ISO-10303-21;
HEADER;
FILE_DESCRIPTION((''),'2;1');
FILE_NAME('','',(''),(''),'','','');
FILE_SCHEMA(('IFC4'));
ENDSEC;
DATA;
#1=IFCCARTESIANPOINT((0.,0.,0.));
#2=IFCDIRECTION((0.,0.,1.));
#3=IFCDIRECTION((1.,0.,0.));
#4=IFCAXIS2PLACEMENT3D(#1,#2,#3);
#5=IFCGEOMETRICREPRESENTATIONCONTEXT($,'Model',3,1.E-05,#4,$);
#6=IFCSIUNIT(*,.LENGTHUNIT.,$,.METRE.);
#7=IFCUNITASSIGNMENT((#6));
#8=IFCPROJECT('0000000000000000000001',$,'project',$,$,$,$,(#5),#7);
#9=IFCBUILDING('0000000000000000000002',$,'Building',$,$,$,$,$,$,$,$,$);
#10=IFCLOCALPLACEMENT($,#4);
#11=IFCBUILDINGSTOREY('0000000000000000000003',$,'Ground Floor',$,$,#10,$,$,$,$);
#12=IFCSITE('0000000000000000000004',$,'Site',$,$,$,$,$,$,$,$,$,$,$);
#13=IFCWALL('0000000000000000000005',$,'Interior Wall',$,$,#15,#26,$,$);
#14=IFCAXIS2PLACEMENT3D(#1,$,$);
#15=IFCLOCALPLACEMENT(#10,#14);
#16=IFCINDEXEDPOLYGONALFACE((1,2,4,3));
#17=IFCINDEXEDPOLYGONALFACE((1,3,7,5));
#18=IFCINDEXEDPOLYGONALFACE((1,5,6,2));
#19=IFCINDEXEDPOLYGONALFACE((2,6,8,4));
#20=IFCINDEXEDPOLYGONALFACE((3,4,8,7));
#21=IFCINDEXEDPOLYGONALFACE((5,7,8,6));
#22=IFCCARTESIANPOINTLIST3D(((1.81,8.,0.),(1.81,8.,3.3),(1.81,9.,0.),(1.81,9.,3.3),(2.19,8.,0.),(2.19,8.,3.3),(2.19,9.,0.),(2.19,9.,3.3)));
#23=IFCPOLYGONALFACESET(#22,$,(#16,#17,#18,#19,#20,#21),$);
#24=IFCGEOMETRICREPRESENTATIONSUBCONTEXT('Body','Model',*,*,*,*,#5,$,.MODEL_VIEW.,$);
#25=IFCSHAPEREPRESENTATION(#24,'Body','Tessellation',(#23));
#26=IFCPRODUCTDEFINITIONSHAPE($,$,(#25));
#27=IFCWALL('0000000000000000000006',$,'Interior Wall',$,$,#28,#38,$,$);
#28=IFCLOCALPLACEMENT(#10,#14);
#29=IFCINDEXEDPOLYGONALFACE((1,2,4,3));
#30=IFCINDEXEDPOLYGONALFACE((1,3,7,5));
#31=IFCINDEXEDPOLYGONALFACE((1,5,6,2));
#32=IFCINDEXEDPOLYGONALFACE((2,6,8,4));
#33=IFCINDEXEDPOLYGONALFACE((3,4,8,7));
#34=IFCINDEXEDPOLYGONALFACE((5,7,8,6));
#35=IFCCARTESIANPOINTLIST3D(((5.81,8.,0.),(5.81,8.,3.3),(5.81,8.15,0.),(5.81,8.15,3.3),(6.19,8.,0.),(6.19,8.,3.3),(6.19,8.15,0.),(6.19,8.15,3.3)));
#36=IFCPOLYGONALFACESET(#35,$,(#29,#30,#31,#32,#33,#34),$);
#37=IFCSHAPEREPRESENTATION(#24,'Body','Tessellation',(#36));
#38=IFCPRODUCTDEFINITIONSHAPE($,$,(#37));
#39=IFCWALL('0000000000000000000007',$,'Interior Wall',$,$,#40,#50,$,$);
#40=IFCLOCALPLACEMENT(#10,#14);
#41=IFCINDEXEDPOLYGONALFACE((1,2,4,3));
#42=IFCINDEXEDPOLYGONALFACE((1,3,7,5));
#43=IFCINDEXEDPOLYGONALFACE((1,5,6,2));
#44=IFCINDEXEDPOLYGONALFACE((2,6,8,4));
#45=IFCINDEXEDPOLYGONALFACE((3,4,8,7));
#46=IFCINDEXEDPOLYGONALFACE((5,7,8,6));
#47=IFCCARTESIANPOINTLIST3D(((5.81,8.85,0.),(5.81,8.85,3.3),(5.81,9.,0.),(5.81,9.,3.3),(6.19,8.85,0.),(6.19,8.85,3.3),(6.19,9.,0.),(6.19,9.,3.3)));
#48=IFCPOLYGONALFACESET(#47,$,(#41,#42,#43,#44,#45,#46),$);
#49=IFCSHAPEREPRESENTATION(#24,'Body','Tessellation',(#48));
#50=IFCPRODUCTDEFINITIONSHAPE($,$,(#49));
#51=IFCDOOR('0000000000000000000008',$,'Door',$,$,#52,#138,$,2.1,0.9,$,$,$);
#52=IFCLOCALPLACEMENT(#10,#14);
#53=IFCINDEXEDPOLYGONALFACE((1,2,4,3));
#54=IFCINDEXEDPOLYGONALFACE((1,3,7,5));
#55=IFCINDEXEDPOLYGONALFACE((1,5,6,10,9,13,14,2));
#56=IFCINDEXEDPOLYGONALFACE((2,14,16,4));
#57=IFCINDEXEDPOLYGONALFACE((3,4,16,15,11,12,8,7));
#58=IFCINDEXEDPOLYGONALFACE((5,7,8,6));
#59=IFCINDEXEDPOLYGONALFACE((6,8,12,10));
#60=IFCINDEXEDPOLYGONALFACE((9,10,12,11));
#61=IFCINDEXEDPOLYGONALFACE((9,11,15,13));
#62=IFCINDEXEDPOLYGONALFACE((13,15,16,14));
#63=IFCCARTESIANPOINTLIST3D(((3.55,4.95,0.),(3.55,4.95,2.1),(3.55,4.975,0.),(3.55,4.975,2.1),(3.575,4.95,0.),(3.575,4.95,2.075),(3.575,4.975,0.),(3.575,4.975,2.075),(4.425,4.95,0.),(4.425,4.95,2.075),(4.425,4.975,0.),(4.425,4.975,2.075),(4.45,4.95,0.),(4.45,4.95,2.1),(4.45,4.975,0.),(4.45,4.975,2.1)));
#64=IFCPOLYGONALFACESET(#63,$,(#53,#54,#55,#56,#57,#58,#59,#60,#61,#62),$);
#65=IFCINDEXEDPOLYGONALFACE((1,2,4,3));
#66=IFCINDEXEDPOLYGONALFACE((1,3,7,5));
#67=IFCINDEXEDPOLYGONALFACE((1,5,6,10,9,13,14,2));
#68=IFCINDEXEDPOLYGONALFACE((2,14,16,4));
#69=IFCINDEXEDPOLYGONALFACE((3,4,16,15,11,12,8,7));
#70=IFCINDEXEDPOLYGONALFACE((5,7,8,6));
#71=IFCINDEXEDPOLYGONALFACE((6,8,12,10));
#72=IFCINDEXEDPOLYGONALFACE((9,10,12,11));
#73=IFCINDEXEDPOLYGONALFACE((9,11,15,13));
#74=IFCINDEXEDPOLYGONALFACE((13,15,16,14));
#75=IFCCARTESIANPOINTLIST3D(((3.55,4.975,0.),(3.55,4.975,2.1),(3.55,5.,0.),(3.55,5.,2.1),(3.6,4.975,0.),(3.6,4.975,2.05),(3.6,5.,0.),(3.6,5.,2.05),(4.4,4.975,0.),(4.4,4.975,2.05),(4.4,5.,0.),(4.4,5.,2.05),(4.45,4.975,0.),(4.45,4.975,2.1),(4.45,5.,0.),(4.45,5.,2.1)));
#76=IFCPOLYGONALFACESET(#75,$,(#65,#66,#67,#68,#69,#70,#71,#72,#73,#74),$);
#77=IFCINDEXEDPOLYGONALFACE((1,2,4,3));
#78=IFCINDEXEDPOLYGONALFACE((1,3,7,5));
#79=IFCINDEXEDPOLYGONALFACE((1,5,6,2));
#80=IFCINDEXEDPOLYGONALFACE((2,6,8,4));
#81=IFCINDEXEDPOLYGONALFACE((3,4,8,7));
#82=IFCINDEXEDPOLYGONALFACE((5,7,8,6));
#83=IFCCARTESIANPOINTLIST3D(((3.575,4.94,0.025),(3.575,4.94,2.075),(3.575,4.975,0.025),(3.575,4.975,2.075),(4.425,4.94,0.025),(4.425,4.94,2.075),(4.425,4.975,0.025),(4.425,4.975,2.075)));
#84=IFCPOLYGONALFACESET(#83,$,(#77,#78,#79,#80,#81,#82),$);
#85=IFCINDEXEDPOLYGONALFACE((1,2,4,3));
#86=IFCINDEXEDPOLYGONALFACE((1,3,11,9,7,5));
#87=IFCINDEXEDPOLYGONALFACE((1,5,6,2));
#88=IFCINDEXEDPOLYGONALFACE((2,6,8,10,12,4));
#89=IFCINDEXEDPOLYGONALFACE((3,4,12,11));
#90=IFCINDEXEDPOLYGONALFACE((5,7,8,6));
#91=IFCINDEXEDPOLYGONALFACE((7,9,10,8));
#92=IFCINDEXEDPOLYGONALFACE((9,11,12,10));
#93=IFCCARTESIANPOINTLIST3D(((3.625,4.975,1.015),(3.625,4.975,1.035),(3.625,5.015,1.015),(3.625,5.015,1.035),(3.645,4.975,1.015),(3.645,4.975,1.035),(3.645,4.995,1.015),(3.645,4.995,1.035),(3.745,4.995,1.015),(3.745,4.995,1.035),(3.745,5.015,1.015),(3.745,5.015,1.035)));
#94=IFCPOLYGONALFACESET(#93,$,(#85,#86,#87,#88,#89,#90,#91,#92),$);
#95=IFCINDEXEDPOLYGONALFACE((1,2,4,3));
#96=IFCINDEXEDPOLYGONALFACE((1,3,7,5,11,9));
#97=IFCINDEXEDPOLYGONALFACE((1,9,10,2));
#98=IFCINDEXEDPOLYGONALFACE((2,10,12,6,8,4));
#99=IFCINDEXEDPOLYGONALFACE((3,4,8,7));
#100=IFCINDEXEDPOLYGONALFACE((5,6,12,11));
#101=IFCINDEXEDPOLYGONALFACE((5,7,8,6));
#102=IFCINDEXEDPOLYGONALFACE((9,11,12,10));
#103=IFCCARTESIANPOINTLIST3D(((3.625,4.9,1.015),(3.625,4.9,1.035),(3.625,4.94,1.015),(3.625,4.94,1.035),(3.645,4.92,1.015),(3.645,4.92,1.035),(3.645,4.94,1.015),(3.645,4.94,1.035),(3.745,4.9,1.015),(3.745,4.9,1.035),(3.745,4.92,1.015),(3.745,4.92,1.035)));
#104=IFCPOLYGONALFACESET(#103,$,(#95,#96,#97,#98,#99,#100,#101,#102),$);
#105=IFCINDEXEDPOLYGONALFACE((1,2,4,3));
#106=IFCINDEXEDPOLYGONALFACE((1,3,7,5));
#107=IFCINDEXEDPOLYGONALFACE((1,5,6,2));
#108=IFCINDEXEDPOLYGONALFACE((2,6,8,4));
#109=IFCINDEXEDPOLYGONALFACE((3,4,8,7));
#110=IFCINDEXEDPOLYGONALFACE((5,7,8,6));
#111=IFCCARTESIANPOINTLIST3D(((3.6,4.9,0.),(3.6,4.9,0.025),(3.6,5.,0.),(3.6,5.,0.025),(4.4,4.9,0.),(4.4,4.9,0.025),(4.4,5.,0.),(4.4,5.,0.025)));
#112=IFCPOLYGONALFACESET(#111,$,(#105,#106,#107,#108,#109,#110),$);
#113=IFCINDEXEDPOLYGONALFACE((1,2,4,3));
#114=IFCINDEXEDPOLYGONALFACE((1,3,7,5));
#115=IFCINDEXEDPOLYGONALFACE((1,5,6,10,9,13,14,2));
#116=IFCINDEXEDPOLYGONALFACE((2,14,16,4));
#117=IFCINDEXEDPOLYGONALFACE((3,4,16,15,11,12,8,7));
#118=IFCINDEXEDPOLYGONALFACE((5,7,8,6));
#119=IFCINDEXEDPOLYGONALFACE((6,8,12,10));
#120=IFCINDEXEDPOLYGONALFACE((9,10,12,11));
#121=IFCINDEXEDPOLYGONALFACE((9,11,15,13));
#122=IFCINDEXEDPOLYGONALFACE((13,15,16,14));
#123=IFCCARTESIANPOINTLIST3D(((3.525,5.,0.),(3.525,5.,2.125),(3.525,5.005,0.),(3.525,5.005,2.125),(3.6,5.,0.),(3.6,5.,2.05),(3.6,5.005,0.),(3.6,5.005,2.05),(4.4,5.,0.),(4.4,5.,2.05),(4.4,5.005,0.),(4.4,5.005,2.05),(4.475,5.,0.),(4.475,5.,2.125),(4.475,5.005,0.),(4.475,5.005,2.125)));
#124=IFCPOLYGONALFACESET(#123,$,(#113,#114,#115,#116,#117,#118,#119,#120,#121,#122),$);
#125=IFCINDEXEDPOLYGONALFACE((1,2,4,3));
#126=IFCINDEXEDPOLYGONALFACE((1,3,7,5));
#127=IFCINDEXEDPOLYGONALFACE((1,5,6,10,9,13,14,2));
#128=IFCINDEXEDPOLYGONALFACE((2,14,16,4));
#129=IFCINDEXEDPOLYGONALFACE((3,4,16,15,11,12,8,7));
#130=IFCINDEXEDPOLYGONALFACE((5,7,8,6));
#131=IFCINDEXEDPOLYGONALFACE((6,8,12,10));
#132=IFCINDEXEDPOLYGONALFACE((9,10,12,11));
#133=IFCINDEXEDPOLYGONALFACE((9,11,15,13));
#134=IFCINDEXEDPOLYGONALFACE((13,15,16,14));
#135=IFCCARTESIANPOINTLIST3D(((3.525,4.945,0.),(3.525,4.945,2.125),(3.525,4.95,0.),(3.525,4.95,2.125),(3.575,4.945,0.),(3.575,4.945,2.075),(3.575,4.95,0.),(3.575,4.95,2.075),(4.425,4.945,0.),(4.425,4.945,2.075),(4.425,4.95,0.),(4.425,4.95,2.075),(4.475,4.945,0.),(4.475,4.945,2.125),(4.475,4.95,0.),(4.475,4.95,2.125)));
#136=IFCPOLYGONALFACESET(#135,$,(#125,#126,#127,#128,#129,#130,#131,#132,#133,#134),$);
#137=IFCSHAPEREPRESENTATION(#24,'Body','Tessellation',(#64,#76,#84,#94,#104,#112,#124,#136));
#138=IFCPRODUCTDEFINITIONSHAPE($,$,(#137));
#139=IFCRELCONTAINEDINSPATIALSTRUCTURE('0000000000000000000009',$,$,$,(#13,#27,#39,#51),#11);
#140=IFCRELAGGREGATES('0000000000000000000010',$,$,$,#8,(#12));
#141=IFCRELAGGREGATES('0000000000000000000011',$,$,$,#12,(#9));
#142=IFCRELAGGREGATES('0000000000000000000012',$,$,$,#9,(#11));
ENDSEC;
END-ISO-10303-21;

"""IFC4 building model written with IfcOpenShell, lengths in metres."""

from ifc_helpers import new_model, si_unit, frame, origin_with_axes, place, context, subcontext, project, spatial, line, indexed_curve, outline, extrude, element, save


model = new_model("IFC4")

# Units and contexts
model_context = context("Model", 3, precision=1e-05, world=origin_with_axes())
body_context = subcontext(model_context, "Body", "Model", "MODEL_VIEW")
ifc_project = project(units=[si_unit("LENGTHUNIT", "METRE")], contexts=[model_context])

# Site, building, storey
site = spatial("IfcSite", under=ifc_project, Name="Site")
building = spatial("IfcBuilding", under=site, Name="Building")
storey_placement = place(None, origin_with_axes())
storey = spatial("IfcBuildingStorey", under=building, at=storey_placement, Name="Ground Floor")

# Walls
wall_1_placement = place(storey_placement, frame((2.0, 8.0, 0.0), z_axis=(0.0, 0.0, 1.0), x_axis=(0.0, 1.0, 0.0)))
element("IfcWall", 1, at=wall_1_placement, inside=storey, Name="Interior Wall", context=body_context, shape_type="SweptSolid", body=[
    extrude(outline(indexed_curve([(0.0, 0.0), (0.0, 0.38), (1.0, 0.38), (1.0, 0.0), (0.0, 0.0)], self_intersect=False)), frame((0.0, -0.19, 0.0), z_axis=(0.0, 0.0, 1.0), x_axis=(1.0, 0.0, 0.0)), (0.0, 0.0, 1.0), 3.3),
])
for number, where, z_axis, x_axis, name in (
    (2, (6.0, 8.0, 0.0), (0.0, 0.0, 1.0), (0.0, 1.0, 0.0), "Interior Wall"),
    (3, (6.0, 8.85, 0.0), (0.0, 0.0, 1.0), (0.0, 1.0, 0.0), "Interior Wall"),
):
    element("IfcWall", number, at=place(storey_placement, frame(where, z_axis=z_axis, x_axis=x_axis)), inside=storey, Name=name, context=body_context, shape_type="SweptSolid", body=[
        extrude(outline(indexed_curve([(0.0, 0.0), (0.0, 0.38), (0.15, 0.38), (0.15, 0.0), (0.0, 0.0)], self_intersect=False)), frame((0.0, -0.19, 0.0), z_axis=(0.0, 0.0, 1.0), x_axis=(1.0, 0.0, 0.0)), (0.0, 0.0, 1.0), 3.3),
    ])

# Door
door_1_placement = place(storey_placement, frame((4.45, 5.0, 0.0), z_axis=(0.0, 0.0, 1.0), x_axis=(-1.0, 0.0, 0.0)))
element("IfcDoor", 4, at=door_1_placement, inside=storey, Name="Door", OverallHeight=2.1, OverallWidth=0.9, context=body_context, shape_type="SweptSolid", body=[
    extrude(outline(indexed_curve([(0.0, 0.0), (0.0, 2.1), (0.9, 2.1), (0.9, 0.0), (0.875, 0.0), (0.875, 2.075), (0.025, 2.075), (0.025, 0.0)], segments=[line(1, 2, 3, 4, 5, 6, 7, 8, 1)])), frame((0.0, 0.025, 0.0), z_axis=(0.0, -1.0, 0.0), x_axis=(1.0, 0.0, 0.0)), (0.0, 0.0, -1.0), 0.025),
    extrude(outline(indexed_curve([(0.0, 0.0), (0.0, 2.1), (0.9, 2.1), (0.9, 0.0), (0.85, 0.0), (0.85, 2.05), (0.05, 2.05), (0.05, 0.0)], segments=[line(1, 2, 3, 4, 5, 6, 7, 8, 1)])), frame((0.0, 0.0, 0.0), z_axis=(0.0, -1.0, 0.0), x_axis=(1.0, 0.0, 0.0)), (0.0, 0.0, -1.0), 0.025),
    extrude(outline(indexed_curve([(0.0, 0.0), (0.85, 0.0), (0.85, 0.035), (0.0, 0.035)], segments=[line(1, 2, 3, 4, 1)])), frame((0.025, 0.025, 0.025), z_axis=(0.0, 0.0, 1.0), x_axis=(1.0, 0.0, 0.0)), (0.0, 0.0, 1.0), 2.05),
    extrude(outline(indexed_curve([(0.0, 0.0), (0.0, -0.04), (-0.12, -0.04), (-0.12, -0.02), (-0.02, -0.02), (-0.02, 0.0)], segments=[line(1, 2, 3, 4, 5, 6, 1)])), frame((0.825, 0.025, 1.015), z_axis=(0.0, 0.0, 1.0), x_axis=(1.0, 0.0, 0.0)), (0.0, 0.0, 1.0), 0.02),
    extrude(outline(indexed_curve([(0.0, 0.0), (0.0, 0.04), (-0.12, 0.04), (-0.12, 0.02), (-0.02, 0.02), (-0.02, 0.0)], segments=[line(1, 2, 3, 4, 5, 6, 1)])), frame((0.825, 0.06, 1.015), z_axis=(0.0, 0.0, 1.0), x_axis=(1.0, 0.0, 0.0)), (0.0, 0.0, 1.0), 0.02),
    extrude(outline(indexed_curve([(0.0, 0.0), (0.8, 0.0), (0.8, 0.1), (0.0, 0.1)], segments=[line(1, 2, 3, 4, 1)])), frame((0.05, 0.0, 0.0), z_axis=(0.0, 0.0, 1.0), x_axis=(1.0, 0.0, 0.0)), (0.0, 0.0, 1.0), 0.025),
    extrude(outline(indexed_curve([(0.0, 0.0), (0.0, 2.125), (0.95, 2.125), (0.95, 0.0), (0.875, 0.0), (0.875, 2.05), (0.075, 2.05), (0.075, 0.0)], segments=[line(1, 2, 3, 4, 5, 6, 7, 8, 1)])), frame((-0.025, -0.005, 0.0), z_axis=(0.0, -1.0, 0.0), x_axis=(1.0, 0.0, 0.0)), (0.0, 0.0, -1.0), 0.005),
    extrude(outline(indexed_curve([(0.0, 0.0), (0.0, 2.125), (0.95, 2.125), (0.95, 0.0), (0.9, 0.0), (0.9, 2.075), (0.05, 2.075), (0.05, 0.0)], segments=[line(1, 2, 3, 4, 5, 6, 7, 8, 1)])), frame((-0.025, 0.05, 0.0), z_axis=(0.0, -1.0, 0.0), x_axis=(1.0, 0.0, 0.0)), (0.0, 0.0, -1.0), 0.005),
])

save(model, "model.ifc")
